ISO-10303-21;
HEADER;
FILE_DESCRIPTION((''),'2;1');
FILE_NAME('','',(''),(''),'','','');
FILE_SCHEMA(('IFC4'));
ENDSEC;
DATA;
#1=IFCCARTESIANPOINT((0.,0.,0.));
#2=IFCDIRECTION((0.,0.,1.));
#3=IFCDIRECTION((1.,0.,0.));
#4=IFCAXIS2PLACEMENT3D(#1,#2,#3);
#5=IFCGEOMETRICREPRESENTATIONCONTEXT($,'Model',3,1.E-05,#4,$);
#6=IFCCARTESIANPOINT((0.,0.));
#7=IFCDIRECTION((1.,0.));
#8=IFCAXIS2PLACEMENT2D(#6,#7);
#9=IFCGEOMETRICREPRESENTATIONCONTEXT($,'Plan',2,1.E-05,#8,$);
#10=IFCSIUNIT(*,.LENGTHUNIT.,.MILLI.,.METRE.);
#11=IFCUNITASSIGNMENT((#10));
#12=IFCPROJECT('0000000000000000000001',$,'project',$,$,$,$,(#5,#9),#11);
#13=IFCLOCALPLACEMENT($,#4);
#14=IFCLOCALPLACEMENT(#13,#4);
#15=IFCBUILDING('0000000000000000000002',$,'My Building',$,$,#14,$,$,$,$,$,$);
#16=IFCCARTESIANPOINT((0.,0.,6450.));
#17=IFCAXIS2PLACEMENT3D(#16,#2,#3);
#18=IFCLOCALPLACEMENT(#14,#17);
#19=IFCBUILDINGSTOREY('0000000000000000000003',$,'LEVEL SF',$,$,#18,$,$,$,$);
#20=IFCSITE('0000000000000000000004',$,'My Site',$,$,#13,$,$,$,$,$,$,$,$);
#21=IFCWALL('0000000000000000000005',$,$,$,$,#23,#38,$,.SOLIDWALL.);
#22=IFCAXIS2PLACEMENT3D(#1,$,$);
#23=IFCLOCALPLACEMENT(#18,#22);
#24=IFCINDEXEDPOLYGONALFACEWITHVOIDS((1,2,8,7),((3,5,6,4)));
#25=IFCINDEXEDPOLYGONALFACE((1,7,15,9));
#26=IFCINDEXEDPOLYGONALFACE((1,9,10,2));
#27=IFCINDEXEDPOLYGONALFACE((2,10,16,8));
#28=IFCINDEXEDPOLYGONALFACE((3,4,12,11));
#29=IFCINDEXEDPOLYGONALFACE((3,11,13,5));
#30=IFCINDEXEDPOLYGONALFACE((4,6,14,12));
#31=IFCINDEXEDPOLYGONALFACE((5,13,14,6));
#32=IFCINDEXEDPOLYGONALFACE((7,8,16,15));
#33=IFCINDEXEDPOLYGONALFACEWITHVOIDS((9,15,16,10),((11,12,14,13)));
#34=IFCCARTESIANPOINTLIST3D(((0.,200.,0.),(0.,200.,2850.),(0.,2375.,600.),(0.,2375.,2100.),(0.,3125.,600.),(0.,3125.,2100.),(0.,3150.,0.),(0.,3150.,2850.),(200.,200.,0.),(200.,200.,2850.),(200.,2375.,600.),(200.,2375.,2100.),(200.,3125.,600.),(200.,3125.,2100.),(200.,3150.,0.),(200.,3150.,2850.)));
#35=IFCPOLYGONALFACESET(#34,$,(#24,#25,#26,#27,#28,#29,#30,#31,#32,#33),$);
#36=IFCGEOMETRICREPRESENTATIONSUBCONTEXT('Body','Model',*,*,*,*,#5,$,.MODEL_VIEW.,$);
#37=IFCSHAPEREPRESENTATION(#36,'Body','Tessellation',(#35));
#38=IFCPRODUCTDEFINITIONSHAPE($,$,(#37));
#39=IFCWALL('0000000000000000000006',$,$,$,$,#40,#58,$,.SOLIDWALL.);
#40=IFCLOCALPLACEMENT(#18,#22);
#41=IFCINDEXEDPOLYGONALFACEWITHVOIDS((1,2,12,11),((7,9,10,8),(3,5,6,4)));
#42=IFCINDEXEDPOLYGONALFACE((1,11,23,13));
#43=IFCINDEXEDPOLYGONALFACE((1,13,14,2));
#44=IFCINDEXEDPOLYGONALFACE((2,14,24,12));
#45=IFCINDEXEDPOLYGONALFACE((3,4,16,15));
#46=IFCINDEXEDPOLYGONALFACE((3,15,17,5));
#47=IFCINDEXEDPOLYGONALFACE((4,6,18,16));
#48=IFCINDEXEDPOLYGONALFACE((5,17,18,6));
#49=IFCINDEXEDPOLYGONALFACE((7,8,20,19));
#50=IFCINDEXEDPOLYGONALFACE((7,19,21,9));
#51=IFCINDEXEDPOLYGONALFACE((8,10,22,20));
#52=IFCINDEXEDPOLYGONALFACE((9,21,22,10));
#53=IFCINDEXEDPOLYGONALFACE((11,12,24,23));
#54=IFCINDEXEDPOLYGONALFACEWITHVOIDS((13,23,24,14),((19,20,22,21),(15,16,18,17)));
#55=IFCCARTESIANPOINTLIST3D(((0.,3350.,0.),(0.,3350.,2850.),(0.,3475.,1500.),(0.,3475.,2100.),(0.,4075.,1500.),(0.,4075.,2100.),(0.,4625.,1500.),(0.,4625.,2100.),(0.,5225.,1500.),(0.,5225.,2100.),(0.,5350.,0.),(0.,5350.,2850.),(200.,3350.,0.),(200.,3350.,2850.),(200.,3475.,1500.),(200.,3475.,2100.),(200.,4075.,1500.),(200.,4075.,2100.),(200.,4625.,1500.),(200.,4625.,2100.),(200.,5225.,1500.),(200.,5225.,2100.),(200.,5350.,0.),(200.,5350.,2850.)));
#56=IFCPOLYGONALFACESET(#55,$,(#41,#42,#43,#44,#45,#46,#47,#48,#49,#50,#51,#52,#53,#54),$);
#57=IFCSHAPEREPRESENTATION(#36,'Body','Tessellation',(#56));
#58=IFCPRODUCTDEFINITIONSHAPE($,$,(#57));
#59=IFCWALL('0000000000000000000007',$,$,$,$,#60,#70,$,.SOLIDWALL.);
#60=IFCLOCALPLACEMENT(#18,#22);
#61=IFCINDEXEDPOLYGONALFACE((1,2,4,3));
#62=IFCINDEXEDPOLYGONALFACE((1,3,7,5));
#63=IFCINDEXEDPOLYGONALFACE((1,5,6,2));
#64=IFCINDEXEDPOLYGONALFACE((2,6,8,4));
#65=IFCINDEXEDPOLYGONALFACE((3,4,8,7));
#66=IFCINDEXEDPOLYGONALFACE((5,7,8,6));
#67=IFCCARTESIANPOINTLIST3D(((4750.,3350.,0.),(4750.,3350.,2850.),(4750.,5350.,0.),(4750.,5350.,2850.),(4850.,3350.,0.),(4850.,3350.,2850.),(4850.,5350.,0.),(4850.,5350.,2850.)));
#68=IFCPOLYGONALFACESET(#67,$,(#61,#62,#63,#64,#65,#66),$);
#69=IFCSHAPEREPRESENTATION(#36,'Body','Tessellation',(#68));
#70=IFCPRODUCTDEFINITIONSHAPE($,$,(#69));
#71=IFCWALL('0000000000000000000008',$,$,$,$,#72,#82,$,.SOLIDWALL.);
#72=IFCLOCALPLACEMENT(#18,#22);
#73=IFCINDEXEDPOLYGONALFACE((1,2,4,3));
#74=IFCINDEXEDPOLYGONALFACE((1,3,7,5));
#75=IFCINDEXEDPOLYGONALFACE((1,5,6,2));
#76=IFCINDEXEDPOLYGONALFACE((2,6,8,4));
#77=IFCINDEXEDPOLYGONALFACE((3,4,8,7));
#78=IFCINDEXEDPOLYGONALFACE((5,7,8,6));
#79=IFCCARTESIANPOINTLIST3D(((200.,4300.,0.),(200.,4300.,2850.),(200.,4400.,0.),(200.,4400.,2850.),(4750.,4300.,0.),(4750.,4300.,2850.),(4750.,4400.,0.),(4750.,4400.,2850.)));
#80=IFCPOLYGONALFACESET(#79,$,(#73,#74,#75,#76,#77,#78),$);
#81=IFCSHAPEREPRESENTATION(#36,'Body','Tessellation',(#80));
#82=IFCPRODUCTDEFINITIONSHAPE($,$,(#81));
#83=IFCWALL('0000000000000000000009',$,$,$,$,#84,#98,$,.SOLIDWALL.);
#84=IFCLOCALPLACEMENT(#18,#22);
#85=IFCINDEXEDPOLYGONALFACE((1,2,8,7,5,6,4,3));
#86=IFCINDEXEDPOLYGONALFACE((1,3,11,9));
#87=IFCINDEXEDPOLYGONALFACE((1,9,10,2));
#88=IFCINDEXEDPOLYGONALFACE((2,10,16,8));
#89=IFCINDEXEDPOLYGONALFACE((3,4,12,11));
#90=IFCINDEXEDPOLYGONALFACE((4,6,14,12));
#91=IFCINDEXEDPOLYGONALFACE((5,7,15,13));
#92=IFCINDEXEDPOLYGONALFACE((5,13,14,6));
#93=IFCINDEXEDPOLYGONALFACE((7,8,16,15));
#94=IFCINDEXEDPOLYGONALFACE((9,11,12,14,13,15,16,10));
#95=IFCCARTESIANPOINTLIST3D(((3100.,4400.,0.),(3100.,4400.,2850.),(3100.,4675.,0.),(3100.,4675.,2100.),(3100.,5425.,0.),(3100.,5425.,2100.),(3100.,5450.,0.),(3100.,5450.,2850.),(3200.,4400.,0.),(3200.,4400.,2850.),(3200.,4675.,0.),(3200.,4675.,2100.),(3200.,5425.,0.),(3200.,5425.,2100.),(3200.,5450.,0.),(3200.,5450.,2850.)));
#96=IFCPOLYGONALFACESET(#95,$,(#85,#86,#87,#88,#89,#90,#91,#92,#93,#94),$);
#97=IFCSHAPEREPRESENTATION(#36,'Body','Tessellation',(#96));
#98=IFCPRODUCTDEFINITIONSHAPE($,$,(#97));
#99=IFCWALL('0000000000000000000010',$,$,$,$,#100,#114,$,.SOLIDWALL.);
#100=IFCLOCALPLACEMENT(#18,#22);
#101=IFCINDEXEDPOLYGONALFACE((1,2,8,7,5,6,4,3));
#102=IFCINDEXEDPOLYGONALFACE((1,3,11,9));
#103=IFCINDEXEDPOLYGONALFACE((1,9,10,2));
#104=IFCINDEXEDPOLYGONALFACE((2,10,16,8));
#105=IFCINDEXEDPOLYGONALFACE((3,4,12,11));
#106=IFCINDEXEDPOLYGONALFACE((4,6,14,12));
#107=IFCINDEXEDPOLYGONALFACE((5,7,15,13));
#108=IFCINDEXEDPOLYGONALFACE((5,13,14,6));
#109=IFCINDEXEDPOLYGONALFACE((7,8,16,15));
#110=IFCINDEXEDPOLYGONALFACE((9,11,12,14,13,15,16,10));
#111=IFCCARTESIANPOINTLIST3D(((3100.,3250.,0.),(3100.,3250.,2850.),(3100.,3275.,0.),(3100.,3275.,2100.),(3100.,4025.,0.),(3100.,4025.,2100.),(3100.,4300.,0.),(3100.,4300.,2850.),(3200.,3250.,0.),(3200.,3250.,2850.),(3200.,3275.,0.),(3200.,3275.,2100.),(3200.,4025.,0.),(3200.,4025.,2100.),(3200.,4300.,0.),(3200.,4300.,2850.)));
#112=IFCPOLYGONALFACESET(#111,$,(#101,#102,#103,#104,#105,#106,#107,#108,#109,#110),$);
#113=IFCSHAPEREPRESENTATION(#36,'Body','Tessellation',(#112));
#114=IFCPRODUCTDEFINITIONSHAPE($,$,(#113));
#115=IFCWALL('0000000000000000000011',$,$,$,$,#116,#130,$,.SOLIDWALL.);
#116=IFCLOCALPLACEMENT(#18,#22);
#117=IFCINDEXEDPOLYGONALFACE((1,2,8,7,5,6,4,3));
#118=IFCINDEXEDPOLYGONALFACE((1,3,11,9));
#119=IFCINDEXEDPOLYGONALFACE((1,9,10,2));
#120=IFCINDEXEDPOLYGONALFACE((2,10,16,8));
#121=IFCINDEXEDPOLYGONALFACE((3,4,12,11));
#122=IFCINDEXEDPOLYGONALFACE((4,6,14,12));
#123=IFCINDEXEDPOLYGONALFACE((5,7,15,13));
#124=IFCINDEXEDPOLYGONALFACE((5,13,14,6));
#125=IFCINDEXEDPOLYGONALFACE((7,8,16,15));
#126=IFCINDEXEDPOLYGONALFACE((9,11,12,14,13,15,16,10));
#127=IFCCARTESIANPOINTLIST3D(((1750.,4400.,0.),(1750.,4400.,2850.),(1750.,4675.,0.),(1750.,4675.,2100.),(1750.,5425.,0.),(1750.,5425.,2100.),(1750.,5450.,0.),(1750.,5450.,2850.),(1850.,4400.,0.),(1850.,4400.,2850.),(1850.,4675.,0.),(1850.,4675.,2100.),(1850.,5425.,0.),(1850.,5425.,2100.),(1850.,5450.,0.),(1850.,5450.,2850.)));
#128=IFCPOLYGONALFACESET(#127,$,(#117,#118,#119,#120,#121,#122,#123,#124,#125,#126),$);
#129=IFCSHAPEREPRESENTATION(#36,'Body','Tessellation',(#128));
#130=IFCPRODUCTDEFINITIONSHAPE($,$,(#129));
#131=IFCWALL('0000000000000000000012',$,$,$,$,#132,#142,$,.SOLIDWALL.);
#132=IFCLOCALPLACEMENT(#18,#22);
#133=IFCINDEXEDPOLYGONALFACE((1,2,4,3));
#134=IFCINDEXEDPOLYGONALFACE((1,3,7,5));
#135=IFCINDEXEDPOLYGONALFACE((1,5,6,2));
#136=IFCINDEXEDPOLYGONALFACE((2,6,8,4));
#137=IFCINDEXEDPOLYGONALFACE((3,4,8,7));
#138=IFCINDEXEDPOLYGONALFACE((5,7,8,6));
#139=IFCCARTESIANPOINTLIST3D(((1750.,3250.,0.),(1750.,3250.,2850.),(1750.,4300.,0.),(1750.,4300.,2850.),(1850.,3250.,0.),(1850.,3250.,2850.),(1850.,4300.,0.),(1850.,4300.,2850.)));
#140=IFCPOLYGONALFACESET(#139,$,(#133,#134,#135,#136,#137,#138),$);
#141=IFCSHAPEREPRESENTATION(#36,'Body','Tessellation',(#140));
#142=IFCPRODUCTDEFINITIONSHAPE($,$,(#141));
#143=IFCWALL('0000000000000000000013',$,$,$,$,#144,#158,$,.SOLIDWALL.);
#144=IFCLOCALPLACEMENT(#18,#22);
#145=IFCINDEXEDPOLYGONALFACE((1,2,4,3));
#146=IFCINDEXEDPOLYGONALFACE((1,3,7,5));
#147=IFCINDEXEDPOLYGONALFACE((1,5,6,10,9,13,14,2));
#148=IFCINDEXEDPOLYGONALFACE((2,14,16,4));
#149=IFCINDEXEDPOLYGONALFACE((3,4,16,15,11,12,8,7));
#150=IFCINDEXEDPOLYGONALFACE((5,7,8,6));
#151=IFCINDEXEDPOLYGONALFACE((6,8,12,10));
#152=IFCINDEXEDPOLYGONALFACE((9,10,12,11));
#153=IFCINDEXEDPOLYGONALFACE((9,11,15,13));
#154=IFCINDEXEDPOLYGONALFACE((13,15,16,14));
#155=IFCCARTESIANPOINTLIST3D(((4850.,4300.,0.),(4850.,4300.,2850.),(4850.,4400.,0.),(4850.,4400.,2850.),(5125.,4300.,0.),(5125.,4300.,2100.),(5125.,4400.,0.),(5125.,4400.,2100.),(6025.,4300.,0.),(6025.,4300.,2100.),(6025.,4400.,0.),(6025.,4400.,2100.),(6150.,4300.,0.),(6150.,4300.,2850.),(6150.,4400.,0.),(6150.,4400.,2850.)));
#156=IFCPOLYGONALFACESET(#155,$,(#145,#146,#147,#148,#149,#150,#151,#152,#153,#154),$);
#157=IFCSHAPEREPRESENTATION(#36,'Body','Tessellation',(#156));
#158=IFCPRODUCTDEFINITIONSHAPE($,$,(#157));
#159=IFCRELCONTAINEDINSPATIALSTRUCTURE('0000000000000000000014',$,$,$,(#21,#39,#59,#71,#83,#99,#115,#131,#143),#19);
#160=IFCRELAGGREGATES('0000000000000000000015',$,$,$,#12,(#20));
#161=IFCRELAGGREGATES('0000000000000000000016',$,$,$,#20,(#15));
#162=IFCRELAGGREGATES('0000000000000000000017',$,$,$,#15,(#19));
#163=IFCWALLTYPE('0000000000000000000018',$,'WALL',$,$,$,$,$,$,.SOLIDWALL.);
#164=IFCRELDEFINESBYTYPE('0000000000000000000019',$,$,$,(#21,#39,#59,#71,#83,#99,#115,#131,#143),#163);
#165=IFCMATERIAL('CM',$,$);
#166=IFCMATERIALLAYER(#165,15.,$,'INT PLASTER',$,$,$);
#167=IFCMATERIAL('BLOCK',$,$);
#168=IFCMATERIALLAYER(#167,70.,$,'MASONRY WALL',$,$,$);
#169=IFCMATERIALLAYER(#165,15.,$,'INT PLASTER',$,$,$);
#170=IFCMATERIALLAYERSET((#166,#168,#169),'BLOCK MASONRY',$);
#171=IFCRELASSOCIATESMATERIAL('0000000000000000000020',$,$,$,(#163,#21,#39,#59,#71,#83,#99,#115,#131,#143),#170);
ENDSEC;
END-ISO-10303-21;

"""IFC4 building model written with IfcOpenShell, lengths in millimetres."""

from ifc_helpers import new_model, si_unit, frame, origin_with_axes, origin_2d_with_axis, place, context, subcontext, project, spatial, indexed_curve, outline, extrude, material, layer, layer_set, layer_usage, type_object, element, save


model = new_model("IFC4")

# Units and contexts
model_context = context("Model", 3, precision=1e-05, world=origin_with_axes())
plan_context = context("Plan", 2, precision=1e-05, world=origin_2d_with_axis())
body_context = subcontext(model_context, "Body", "Model", "MODEL_VIEW")
ifc_project = project(units=[si_unit("LENGTHUNIT", "METRE", prefix="MILLI")], contexts=[model_context, plan_context])

# Site, building, storey
site_placement = place(None, origin_with_axes())
site = spatial("IfcSite", under=ifc_project, at=site_placement, Name="My Site")
building_placement = place(site_placement, origin_with_axes())
building = spatial("IfcBuilding", under=site, at=building_placement, Name="My Building")
storey_placement = place(building_placement, frame((0.0, 0.0, 6450.0), z_axis=(0.0, 0.0, 1.0), x_axis=(1.0, 0.0, 0.0)))
storey = spatial("IfcBuildingStorey", under=building, at=storey_placement, Name="LEVEL SF")

# Shared definitions
ifc_material_1 = material(Name="CM")
ifc_layer_1 = layer(ifc_material_1, 15.0, Name="INT PLASTER")
ifc_material_2 = material(Name="BLOCK")
ifc_layer_2 = layer(ifc_material_2, 70.0, Name="MASONRY WALL")
ifc_layer_3 = layer(ifc_material_1, 15.0, Name="INT PLASTER")
ifc_layer_set_1 = layer_set([ifc_layer_1, ifc_layer_2, ifc_layer_3], Name="BLOCK MASONRY")
wall_type = type_object("IfcWallType", Name="WALL", PredefinedType="SOLIDWALL", material=ifc_layer_set_1)

# Wall, opening
ifc_layer_usage_1 = layer_usage(ifc_layer_set_1, "AXIS2", "POSITIVE", 0.0)
wall_1_placement = place(storey_placement, frame((200.0, 200.0, 0.0), z_axis=(0.0, 0.0, 1.0), x_axis=(0.0, 1.0, 0.0)))
wall_1 = element("IfcWall", 1, at=wall_1_placement, inside=storey, type_object=wall_type, material=ifc_layer_usage_1, PredefinedType="SOLIDWALL", context=body_context, shape_type="SweptSolid", body=[
    extrude(outline(indexed_curve([(0.0, 0.0), (0.0, 200.0), (2950.0, 200.0), (2950.0, 0.0), (0.0, 0.0)], self_intersect=False)), origin_with_axes(), (0.0, 0.0, 1.0), 2850.0),
])
opening_1_placement = place(wall_1_placement, frame((2175.0, 0.0, 600.0), z_axis=(0.0, 0.0, 1.0), x_axis=(1.0, 0.0, 0.0)))
element("IfcOpeningElement", 2, at=opening_1_placement, cuts=wall_1, PredefinedType="OPENING", context=body_context, shape_type="SweptSolid", body=[
    extrude(outline(indexed_curve([(0.0, 0.0), (0.0, 400.0), (750.0, 400.0), (750.0, 0.0), (0.0, 0.0)], self_intersect=False)), frame((0.0, -100.0, 0.0), z_axis=(0.0, 0.0, 1.0), x_axis=(1.0, 0.0, 0.0)), (0.0, 0.0, 1.0), 1500.0),
])

# Wall, openings
ifc_layer_usage_2 = layer_usage(ifc_layer_set_1, "AXIS2", "POSITIVE", 0.0)
wall_2_placement = place(storey_placement, frame((200.0, 3350.0, 0.0), z_axis=(0.0, 0.0, 1.0), x_axis=(0.0, 1.0, 0.0)))
wall_2 = element("IfcWall", 3, at=wall_2_placement, inside=storey, type_object=wall_type, material=ifc_layer_usage_2, PredefinedType="SOLIDWALL", context=body_context, shape_type="SweptSolid", body=[
    extrude(outline(indexed_curve([(0.0, 0.0), (0.0, 200.0), (2000.0, 200.0), (2000.0, 0.0), (0.0, 0.0)], self_intersect=False)), origin_with_axes(), (0.0, 0.0, 1.0), 2850.0),
])
opening_2_placement = place(wall_2_placement, frame((1275.0, 0.0, 1500.0), z_axis=(0.0, 0.0, 1.0), x_axis=(1.0, 0.0, 0.0)))
element("IfcOpeningElement", 4, at=opening_2_placement, cuts=wall_2, PredefinedType="OPENING", context=body_context, shape_type="SweptSolid", body=[
    extrude(outline(indexed_curve([(0.0, 0.0), (0.0, 400.0), (600.0, 400.0), (600.0, 0.0), (0.0, 0.0)], self_intersect=False)), frame((0.0, -100.0, 0.0), z_axis=(0.0, 0.0, 1.0), x_axis=(1.0, 0.0, 0.0)), (0.0, 0.0, 1.0), 600.0),
])
opening_3_placement = place(wall_2_placement, frame((125.0, 0.0, 1500.0), z_axis=(0.0, 0.0, 1.0), x_axis=(1.0, 0.0, 0.0)))
element("IfcOpeningElement", 5, at=opening_3_placement, cuts=wall_2, PredefinedType="OPENING", context=body_context, shape_type="SweptSolid", body=[
    extrude(outline(indexed_curve([(0.0, 0.0), (0.0, 400.0), (600.0, 400.0), (600.0, 0.0), (0.0, 0.0)], self_intersect=False)), frame((0.0, -100.0, 0.0), z_axis=(0.0, 0.0, 1.0), x_axis=(1.0, 0.0, 0.0)), (0.0, 0.0, 1.0), 600.0),
])

# Walls
ifc_layer_usage_3 = layer_usage(ifc_layer_set_1, "AXIS2", "POSITIVE", 0.0)
wall_3_placement = place(storey_placement, frame((4850.0, 3350.0, 0.0), z_axis=(0.0, 0.0, 1.0), x_axis=(0.0, 1.0, 0.0)))
element("IfcWall", 6, at=wall_3_placement, inside=storey, type_object=wall_type, material=ifc_layer_usage_3, PredefinedType="SOLIDWALL", context=body_context, shape_type="SweptSolid", body=[
    extrude(outline(indexed_curve([(0.0, 0.0), (0.0, 100.0), (2000.0, 100.0), (2000.0, 0.0), (0.0, 0.0)], self_intersect=False)), origin_with_axes(), (0.0, 0.0, 1.0), 2850.0),
])
ifc_layer_usage_4 = layer_usage(ifc_layer_set_1, "AXIS2", "POSITIVE", 0.0)
wall_4_placement = place(storey_placement, frame((200.0, 4400.0, 0.0), z_axis=(0.0, 0.0, 1.0), x_axis=(0.0, -1.0, 0.0)))
element("IfcWall", 7, at=wall_4_placement, inside=storey, type_object=wall_type, material=ifc_layer_usage_4, PredefinedType="SOLIDWALL", context=body_context, shape_type="SweptSolid", body=[
    extrude(outline(indexed_curve([(0.0, 0.0), (0.0, 4550.0), (100.0, 4550.0), (100.0, 0.0), (0.0, 0.0)], self_intersect=False)), origin_with_axes(), (0.0, 0.0, 1.0), 2850.0),
])

# Walls, openings
ifc_layer_usage_5 = layer_usage(ifc_layer_set_1, "AXIS2", "POSITIVE", 0.0)
wall_5_placement = place(storey_placement, frame((3200.0, 4400.0, 0.0), z_axis=(0.0, 0.0, 1.0), x_axis=(0.0, 1.0, 0.0)))
wall_5 = element("IfcWall", 8, at=wall_5_placement, inside=storey, type_object=wall_type, material=ifc_layer_usage_5, PredefinedType="SOLIDWALL", context=body_context, shape_type="SweptSolid", body=[
    extrude(outline(indexed_curve([(0.0, 0.0), (0.0, 100.0), (1050.0, 100.0), (1050.0, 0.0), (0.0, 0.0)], self_intersect=False)), origin_with_axes(), (0.0, 0.0, 1.0), 2850.0),
])
opening_4_placement = place(wall_5_placement, frame((1025.0, 100.0, 0.0), z_axis=(0.0, 0.0, 1.0), x_axis=(-1.0, 0.0, 0.0)))
element("IfcOpeningElement", 9, at=opening_4_placement, cuts=wall_5, PredefinedType="OPENING", context=body_context, shape_type="SweptSolid", body=[
    extrude(outline(indexed_curve([(0.0, 0.0), (0.0, 400.0), (750.0, 400.0), (750.0, 0.0), (0.0, 0.0)], self_intersect=False)), frame((0.0, -100.0, 0.0), z_axis=(0.0, 0.0, 1.0), x_axis=(1.0, 0.0, 0.0)), (0.0, 0.0, 1.0), 2100.0),
])
ifc_layer_usage_6 = layer_usage(ifc_layer_set_1, "AXIS2", "POSITIVE", 0.0)
wall_6_placement = place(storey_placement, frame((3200.0, 3250.0, 0.0), z_axis=(0.0, 0.0, 1.0), x_axis=(0.0, 1.0, 0.0)))
wall_6 = element("IfcWall", 10, at=wall_6_placement, inside=storey, type_object=wall_type, material=ifc_layer_usage_6, PredefinedType="SOLIDWALL", context=body_context, shape_type="SweptSolid", body=[
    extrude(outline(indexed_curve([(0.0, 0.0), (0.0, 100.0), (1050.0, 100.0), (1050.0, 0.0), (0.0, 0.0)], self_intersect=False)), origin_with_axes(), (0.0, 0.0, 1.0), 2850.0),
])
opening_5_placement = place(wall_6_placement, frame((775.0, 100.0, 0.0), z_axis=(0.0, 0.0, 1.0), x_axis=(-1.0, 0.0, 0.0)))
element("IfcOpeningElement", 11, at=opening_5_placement, cuts=wall_6, PredefinedType="OPENING", context=body_context, shape_type="SweptSolid", body=[
    extrude(outline(indexed_curve([(0.0, 0.0), (0.0, 400.0), (750.0, 400.0), (750.0, 0.0), (0.0, 0.0)], self_intersect=False)), frame((0.0, -100.0, 0.0), z_axis=(0.0, 0.0, 1.0), x_axis=(1.0, 0.0, 0.0)), (0.0, 0.0, 1.0), 2100.0),
])
ifc_layer_usage_7 = layer_usage(ifc_layer_set_1, "AXIS2", "POSITIVE", 0.0)
wall_7_placement = place(storey_placement, frame((1850.0, 4400.0, 0.0), z_axis=(0.0, 0.0, 1.0), x_axis=(0.0, 1.0, 0.0)))
wall_7 = element("IfcWall", 12, at=wall_7_placement, inside=storey, type_object=wall_type, material=ifc_layer_usage_7, PredefinedType="SOLIDWALL", context=body_context, shape_type="SweptSolid", body=[
    extrude(outline(indexed_curve([(0.0, 0.0), (0.0, 100.0), (1050.0, 100.0), (1050.0, 0.0), (0.0, 0.0)], self_intersect=False)), origin_with_axes(), (0.0, 0.0, 1.0), 2850.0),
])
opening_6_placement = place(wall_7_placement, frame((275.0, 0.0, 0.0), z_axis=(0.0, 0.0, 1.0), x_axis=(1.0, 0.0, 0.0)))
element("IfcOpeningElement", 13, at=opening_6_placement, cuts=wall_7, PredefinedType="OPENING", context=body_context, shape_type="SweptSolid", body=[
    extrude(outline(indexed_curve([(0.0, 0.0), (0.0, 400.0), (750.0, 400.0), (750.0, 0.0), (0.0, 0.0)], self_intersect=False)), frame((0.0, -100.0, 0.0), z_axis=(0.0, 0.0, 1.0), x_axis=(1.0, 0.0, 0.0)), (0.0, 0.0, 1.0), 2100.0),
])

# Wall
ifc_layer_usage_8 = layer_usage(ifc_layer_set_1, "AXIS2", "POSITIVE", 0.0)
wall_8_placement = place(storey_placement, frame((1850.0, 3250.0, 0.0), z_axis=(0.0, 0.0, 1.0), x_axis=(0.0, 1.0, 0.0)))
element("IfcWall", 14, at=wall_8_placement, inside=storey, type_object=wall_type, material=ifc_layer_usage_8, PredefinedType="SOLIDWALL", context=body_context, shape_type="SweptSolid", body=[
    extrude(outline(indexed_curve([(0.0, 0.0), (0.0, 100.0), (1050.0, 100.0), (1050.0, 0.0), (0.0, 0.0)], self_intersect=False)), origin_with_axes(), (0.0, 0.0, 1.0), 2850.0),
])

# Wall, opening
ifc_layer_usage_9 = layer_usage(ifc_layer_set_1, "AXIS2", "POSITIVE", 0.0)
wall_9_placement = place(storey_placement, frame((4850.0, 4400.0, 0.0), z_axis=(0.0, 0.0, 1.0), x_axis=(0.0, -1.0, 0.0)))
wall_9 = element("IfcWall", 15, at=wall_9_placement, inside=storey, type_object=wall_type, material=ifc_layer_usage_9, PredefinedType="SOLIDWALL", context=body_context, shape_type="SweptSolid", body=[
    extrude(outline(indexed_curve([(0.0, 0.0), (0.0, 1300.0), (100.0, 1300.0), (100.0, 0.0), (0.0, 0.0)], self_intersect=False)), origin_with_axes(), (0.0, 0.0, 1.0), 2850.0),
])
opening_7_placement = place(wall_9_placement, frame((0.0, 1175.0, 0.0), z_axis=(0.0, 0.0, 1.0), x_axis=(0.0, -1.0, 0.0)))
element("IfcOpeningElement", 16, at=opening_7_placement, cuts=wall_9, PredefinedType="OPENING", context=body_context, shape_type="SweptSolid", body=[
    extrude(outline(indexed_curve([(0.0, 0.0), (0.0, 400.0), (900.0, 400.0), (900.0, 0.0), (0.0, 0.0)], self_intersect=False)), frame((0.0, -100.0, 0.0), z_axis=(0.0, 0.0, 1.0), x_axis=(1.0, 0.0, 0.0)), (0.0, 0.0, 1.0), 2100.0),
])

save(model, "model.ifc")
